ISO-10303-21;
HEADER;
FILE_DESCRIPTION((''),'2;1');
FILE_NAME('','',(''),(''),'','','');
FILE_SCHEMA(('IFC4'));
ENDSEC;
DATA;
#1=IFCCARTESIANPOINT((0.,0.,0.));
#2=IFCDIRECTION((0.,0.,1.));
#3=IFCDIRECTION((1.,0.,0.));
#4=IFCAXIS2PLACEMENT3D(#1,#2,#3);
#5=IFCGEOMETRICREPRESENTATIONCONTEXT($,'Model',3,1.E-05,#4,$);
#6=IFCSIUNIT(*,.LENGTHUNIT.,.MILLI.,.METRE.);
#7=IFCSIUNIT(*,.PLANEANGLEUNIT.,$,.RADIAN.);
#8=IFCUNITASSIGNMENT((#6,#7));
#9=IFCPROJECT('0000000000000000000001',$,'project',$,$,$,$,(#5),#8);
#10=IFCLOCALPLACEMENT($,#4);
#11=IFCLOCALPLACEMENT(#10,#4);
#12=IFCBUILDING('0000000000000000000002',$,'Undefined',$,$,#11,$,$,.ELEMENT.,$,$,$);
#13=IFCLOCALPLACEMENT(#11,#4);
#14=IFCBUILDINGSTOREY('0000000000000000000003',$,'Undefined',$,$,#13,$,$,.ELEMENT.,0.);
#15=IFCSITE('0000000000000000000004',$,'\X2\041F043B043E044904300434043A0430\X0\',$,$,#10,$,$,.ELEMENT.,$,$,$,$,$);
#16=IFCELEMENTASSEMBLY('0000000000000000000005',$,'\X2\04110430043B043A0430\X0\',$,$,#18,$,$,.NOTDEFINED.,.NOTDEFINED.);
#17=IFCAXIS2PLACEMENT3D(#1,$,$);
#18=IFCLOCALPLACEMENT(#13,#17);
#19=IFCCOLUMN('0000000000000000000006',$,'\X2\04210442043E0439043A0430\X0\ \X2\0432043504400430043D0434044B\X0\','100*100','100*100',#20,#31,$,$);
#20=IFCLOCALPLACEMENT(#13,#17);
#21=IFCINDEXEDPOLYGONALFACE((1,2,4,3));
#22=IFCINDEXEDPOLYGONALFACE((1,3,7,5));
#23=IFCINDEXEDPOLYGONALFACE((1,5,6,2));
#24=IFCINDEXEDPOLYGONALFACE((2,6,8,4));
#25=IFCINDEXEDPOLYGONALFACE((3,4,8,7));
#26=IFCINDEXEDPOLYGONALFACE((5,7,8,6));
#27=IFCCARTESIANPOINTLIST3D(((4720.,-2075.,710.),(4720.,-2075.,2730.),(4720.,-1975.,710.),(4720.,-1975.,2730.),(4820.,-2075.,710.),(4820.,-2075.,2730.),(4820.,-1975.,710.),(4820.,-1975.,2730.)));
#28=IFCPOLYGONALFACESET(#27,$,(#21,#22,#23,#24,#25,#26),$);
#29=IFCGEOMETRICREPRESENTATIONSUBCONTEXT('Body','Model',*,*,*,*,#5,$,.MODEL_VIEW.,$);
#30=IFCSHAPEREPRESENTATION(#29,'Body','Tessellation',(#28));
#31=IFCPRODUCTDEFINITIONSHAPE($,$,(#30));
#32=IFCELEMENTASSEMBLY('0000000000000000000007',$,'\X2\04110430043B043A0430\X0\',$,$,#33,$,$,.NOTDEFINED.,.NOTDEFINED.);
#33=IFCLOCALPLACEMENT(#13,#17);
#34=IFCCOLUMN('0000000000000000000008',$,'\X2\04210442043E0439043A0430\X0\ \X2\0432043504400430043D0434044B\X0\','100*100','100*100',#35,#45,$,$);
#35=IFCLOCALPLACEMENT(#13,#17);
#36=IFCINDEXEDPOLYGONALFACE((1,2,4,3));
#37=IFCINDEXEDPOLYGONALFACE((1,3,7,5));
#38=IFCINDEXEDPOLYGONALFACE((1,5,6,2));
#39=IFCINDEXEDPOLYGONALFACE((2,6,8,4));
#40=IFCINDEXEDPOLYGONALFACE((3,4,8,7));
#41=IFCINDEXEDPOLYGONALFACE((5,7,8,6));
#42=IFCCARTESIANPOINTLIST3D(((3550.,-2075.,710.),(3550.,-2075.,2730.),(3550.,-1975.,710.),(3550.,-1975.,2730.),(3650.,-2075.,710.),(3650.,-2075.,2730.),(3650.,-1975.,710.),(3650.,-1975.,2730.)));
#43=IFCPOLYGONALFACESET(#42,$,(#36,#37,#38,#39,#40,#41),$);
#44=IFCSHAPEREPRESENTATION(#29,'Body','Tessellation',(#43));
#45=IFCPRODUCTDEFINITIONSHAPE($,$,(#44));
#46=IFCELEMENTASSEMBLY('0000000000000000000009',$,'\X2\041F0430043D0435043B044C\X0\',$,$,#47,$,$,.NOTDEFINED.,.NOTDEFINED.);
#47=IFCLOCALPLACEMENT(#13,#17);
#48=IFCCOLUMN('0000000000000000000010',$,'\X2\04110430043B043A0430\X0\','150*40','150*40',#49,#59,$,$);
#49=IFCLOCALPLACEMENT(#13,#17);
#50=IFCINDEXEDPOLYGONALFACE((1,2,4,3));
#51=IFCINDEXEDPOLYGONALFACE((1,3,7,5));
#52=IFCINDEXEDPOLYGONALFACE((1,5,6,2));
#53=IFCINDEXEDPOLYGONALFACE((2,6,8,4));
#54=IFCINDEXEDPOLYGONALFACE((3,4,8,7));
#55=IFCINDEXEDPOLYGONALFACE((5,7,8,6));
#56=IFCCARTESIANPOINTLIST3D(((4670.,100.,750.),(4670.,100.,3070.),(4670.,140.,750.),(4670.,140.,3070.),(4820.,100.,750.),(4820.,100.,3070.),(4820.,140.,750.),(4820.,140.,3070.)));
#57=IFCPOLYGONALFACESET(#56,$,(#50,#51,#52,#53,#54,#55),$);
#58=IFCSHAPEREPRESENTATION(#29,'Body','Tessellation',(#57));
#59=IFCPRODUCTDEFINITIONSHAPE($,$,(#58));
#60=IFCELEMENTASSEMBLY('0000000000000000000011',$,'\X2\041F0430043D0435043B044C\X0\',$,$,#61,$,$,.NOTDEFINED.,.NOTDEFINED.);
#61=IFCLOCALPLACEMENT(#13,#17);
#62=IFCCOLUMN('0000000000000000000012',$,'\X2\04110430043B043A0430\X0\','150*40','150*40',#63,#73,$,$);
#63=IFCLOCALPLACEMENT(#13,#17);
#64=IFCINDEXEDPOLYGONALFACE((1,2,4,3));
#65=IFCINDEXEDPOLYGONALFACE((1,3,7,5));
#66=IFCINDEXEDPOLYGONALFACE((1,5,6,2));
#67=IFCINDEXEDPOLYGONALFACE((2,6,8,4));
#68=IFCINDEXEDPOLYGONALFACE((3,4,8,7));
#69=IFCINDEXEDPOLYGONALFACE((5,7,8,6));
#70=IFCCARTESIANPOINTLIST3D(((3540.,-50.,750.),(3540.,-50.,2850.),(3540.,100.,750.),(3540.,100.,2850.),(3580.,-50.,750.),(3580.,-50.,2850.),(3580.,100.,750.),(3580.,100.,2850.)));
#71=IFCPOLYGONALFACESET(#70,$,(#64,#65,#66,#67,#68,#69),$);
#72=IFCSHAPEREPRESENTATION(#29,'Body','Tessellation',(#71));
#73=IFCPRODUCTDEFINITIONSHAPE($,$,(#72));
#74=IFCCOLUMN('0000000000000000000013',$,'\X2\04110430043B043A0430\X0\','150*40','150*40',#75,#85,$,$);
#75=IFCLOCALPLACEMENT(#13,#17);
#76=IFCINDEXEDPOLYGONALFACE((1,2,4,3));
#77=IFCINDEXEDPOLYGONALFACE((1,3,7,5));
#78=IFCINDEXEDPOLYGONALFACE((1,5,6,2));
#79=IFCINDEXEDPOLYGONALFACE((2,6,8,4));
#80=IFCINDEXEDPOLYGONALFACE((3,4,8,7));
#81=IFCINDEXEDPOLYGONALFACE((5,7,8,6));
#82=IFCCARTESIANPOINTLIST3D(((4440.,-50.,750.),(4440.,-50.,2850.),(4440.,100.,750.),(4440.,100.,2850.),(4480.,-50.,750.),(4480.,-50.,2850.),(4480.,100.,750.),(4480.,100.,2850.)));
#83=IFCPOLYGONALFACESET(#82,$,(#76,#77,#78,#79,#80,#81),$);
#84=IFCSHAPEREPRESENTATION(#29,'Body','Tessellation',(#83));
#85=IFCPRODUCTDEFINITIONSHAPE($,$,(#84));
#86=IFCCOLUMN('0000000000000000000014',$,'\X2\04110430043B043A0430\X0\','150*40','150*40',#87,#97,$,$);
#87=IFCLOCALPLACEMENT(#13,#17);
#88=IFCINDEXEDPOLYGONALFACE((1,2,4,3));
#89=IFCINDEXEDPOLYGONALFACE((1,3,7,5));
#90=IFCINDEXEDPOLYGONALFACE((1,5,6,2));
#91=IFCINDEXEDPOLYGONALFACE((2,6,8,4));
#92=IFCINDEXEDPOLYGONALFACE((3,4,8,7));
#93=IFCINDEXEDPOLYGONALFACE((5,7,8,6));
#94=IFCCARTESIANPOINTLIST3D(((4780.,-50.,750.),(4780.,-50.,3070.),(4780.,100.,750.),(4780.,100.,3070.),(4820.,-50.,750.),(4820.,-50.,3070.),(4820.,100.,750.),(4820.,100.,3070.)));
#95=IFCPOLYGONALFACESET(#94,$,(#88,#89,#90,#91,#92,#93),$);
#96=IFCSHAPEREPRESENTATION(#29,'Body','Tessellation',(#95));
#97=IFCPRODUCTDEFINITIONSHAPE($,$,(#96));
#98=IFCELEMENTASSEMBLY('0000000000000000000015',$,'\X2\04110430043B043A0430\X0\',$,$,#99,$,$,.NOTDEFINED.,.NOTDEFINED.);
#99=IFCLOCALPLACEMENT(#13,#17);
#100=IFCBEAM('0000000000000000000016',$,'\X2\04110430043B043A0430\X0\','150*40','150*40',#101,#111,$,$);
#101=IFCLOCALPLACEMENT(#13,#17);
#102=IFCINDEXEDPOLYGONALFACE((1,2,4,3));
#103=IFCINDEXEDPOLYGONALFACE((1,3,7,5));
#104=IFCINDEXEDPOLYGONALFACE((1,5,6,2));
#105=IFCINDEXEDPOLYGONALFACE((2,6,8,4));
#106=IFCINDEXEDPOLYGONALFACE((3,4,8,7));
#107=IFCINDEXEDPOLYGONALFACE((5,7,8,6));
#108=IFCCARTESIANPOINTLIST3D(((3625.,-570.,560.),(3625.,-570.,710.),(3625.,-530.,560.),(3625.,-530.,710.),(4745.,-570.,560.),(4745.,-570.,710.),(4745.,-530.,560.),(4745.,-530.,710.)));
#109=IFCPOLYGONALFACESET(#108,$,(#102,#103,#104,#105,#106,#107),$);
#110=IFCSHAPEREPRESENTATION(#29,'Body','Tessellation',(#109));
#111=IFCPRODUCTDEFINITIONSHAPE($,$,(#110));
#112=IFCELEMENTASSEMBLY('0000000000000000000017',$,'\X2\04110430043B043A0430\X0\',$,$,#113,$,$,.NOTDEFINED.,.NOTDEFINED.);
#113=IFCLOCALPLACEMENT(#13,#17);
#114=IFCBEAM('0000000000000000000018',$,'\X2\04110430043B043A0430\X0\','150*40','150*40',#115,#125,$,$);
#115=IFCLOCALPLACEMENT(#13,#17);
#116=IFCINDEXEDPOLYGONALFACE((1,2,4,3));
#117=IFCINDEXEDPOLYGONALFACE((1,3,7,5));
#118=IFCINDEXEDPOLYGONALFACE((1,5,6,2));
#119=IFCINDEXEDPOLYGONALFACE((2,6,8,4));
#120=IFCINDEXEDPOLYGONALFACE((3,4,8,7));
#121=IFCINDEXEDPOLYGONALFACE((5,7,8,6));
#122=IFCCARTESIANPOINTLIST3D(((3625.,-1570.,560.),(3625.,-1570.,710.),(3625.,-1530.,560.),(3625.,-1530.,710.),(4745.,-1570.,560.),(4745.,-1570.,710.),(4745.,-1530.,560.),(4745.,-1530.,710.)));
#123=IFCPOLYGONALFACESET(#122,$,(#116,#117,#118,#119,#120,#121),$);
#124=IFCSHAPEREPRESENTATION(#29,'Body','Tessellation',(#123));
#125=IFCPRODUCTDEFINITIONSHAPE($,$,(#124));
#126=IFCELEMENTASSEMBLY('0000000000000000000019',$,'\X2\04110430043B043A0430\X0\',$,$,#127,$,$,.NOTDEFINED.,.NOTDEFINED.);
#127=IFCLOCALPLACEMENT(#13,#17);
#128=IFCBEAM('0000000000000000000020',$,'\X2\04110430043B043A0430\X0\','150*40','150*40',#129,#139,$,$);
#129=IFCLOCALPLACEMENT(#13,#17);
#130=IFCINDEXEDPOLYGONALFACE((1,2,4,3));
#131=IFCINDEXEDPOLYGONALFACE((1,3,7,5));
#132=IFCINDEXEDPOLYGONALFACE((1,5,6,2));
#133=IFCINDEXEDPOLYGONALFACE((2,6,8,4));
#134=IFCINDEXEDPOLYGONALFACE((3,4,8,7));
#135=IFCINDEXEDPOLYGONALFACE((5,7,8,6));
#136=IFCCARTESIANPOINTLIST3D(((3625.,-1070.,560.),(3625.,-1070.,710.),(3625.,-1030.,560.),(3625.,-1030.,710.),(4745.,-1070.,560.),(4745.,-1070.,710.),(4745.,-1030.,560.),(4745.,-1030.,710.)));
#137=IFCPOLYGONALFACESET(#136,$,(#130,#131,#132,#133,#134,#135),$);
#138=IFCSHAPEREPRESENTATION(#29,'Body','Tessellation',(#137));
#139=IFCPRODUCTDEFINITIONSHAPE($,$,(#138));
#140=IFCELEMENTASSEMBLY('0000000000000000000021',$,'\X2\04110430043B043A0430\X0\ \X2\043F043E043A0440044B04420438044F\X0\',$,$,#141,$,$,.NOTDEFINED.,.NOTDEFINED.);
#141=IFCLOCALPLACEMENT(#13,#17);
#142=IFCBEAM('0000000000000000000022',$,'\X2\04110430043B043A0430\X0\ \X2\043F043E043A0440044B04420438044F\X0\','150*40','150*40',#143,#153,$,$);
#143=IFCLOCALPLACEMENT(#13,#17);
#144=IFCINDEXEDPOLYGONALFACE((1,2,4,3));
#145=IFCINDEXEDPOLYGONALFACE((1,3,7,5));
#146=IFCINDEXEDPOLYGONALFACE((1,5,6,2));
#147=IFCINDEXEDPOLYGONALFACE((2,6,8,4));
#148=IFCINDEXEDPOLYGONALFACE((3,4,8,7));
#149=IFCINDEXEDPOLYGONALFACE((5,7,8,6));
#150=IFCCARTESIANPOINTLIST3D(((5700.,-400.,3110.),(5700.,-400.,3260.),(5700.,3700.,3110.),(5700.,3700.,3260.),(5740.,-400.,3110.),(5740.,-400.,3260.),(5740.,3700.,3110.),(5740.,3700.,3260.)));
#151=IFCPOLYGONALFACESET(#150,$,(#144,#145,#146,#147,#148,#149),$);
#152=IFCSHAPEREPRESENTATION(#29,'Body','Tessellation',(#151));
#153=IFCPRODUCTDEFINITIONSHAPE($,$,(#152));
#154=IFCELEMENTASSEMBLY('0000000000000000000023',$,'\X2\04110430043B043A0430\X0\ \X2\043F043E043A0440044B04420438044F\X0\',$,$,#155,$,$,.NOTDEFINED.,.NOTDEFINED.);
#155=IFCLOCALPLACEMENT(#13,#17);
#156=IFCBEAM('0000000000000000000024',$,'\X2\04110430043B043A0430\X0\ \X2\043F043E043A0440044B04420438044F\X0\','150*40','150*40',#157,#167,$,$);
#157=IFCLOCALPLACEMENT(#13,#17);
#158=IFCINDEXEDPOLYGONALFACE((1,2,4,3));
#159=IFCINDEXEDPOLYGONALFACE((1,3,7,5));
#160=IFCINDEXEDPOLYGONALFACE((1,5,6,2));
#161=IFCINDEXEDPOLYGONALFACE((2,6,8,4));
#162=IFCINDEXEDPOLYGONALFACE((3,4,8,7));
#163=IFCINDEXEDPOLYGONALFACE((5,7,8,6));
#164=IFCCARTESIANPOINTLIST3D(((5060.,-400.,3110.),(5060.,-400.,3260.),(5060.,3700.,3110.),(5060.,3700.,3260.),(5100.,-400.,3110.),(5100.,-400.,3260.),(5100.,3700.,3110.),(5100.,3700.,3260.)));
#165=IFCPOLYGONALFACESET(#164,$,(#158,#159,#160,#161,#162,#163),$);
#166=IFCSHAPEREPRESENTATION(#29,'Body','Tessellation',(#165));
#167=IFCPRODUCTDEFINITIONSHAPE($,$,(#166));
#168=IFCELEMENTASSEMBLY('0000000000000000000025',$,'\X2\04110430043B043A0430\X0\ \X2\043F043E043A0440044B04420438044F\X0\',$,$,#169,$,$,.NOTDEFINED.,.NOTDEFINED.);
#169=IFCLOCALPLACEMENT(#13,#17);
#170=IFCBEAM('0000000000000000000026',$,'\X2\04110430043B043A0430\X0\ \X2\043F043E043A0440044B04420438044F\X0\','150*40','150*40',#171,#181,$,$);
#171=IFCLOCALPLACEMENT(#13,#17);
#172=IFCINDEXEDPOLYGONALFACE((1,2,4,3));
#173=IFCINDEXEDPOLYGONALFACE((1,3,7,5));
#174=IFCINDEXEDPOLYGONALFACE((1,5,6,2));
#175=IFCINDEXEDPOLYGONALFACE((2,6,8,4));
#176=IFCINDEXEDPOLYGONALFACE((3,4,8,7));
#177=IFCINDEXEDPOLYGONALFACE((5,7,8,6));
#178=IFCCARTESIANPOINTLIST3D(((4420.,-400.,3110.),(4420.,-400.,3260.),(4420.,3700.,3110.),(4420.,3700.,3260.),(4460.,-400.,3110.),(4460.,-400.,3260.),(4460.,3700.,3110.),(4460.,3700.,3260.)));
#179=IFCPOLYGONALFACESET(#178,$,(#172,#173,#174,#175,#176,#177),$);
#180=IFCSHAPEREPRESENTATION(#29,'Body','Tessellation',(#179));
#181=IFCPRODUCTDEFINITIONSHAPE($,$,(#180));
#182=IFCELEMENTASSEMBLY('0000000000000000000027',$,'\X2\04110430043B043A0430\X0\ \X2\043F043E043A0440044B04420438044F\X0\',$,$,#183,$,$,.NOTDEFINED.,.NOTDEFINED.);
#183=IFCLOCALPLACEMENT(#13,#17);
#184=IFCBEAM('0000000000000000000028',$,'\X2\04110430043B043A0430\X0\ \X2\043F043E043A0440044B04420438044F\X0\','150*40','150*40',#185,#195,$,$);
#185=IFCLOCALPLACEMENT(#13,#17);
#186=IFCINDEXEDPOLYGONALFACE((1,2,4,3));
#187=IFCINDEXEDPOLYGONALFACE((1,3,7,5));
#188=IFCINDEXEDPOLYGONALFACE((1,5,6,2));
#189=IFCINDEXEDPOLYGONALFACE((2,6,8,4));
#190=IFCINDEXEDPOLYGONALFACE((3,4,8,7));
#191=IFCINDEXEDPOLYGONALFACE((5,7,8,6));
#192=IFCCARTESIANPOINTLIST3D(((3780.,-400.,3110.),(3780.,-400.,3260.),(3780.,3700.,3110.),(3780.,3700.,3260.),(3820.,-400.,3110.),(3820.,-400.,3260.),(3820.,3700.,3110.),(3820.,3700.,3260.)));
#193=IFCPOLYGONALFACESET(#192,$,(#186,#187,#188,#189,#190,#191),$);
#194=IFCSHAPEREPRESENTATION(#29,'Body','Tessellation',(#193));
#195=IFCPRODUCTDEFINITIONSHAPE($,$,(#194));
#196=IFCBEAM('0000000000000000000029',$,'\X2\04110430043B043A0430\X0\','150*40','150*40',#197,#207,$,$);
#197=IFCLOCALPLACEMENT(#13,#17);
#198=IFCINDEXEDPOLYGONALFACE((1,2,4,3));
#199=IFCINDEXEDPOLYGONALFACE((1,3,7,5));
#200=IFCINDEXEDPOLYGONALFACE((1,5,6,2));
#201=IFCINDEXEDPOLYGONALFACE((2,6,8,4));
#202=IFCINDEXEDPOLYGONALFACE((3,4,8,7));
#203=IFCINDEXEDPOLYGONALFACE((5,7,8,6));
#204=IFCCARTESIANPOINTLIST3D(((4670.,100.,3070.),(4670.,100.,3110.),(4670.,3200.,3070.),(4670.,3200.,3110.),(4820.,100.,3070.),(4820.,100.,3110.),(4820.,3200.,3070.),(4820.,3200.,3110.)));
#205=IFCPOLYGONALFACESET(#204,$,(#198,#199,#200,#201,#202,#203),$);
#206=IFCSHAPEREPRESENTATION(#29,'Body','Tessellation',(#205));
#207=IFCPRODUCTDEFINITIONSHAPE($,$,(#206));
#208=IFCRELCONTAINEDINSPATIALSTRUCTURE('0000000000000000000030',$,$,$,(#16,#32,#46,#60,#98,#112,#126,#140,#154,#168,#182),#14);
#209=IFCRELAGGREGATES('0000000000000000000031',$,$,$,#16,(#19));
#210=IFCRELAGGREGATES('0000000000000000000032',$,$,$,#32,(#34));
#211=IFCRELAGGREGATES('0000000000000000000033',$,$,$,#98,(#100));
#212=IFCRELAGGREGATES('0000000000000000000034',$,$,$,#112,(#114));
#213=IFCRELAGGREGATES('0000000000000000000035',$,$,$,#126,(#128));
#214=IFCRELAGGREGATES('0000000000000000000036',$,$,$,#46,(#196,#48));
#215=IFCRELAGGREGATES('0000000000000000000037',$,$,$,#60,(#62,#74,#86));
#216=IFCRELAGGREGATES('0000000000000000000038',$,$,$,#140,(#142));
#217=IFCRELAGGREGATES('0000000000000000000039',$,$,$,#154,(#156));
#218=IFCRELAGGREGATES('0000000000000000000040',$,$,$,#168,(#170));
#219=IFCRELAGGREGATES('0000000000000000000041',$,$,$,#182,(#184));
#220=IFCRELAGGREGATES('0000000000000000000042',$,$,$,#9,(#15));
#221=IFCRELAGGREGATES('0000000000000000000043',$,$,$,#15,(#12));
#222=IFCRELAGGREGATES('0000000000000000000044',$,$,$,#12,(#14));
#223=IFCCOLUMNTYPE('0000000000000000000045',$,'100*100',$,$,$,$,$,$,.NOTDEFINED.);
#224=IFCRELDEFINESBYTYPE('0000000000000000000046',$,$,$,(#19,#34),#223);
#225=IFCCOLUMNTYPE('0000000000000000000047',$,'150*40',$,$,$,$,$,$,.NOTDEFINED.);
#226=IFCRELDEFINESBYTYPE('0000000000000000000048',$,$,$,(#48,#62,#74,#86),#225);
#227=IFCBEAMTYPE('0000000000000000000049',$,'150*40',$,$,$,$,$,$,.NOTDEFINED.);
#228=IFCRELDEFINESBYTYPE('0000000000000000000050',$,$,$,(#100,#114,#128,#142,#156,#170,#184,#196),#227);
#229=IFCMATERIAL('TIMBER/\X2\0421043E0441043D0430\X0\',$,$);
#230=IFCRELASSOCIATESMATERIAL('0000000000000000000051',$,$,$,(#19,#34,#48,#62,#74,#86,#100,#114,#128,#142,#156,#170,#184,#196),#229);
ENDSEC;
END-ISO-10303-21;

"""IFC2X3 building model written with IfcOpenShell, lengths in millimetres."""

from ifc_helpers import new_model, si_unit, frame, origin_with_axes, origin_2d_with_axis, place, context, subcontext, project, spatial, rectangle, extrude, material, type_object, element, aggregate, save


model = new_model("IFC2X3")

# Units and contexts
model_context = context("Model", 3, precision=1e-05, world=origin_with_axes())
body_context = subcontext(model_context, "Body", "Model", "MODEL_VIEW")
ifc_project = project(units=[si_unit("LENGTHUNIT", "METRE", prefix="MILLI"), si_unit("PLANEANGLEUNIT", "RADIAN")], contexts=[model_context])

# Site, building, storey
site_placement = place(None, origin_with_axes())
site = spatial("IfcSite", under=ifc_project, at=site_placement, Name="Площадка", CompositionType="ELEMENT")
building_placement = place(site_placement, origin_with_axes())
building = spatial("IfcBuilding", under=site, at=building_placement, Name="Undefined", CompositionType="ELEMENT")
storey_placement = place(building_placement, origin_with_axes())
storey = spatial("IfcBuildingStorey", under=building, at=storey_placement, Name="Undefined", CompositionType="ELEMENT", Elevation=0.0)

# Element assemblies, columns
assembly_1_placement = place(storey_placement, origin_with_axes())
assembly_1 = element("IfcElementAssembly", 1, at=assembly_1_placement, inside=storey, Name="Балка", AssemblyPlace="NOTDEFINED", PredefinedType="NOTDEFINED")
ifc_material = material(Name="TIMBER/Сосна")
column_type_1 = type_object("IfcColumnType", Name="100*100", PredefinedType="NOTDEFINED")
column_1_placement = place(assembly_1_placement, frame((4770.0, -2025.0, 710.0), z_axis=(0.0, 0.0, 1.0), x_axis=(0.0, 1.0, 0.0)))
column_1 = element("IfcColumn", 2, at=column_1_placement, type_object=column_type_1, material=ifc_material, Name="Стойка веранды", Description="100*100", ObjectType="100*100", context=body_context, shape_type="SweptSolid", body=[
    extrude(rectangle(XDim=100.0, YDim=100.0, at=origin_2d_with_axis()), frame((0.0, 0.0, 2020.0), z_axis=(0.0, 0.0, -1.0), x_axis=(0.0, 1.0, 0.0)), (0.0, 0.0, 1.0), 2020.0),
])
aggregate(assembly_1, [column_1])
assembly_2_placement = place(storey_placement, origin_with_axes())
assembly_2 = element("IfcElementAssembly", 3, at=assembly_2_placement, inside=storey, Name="Балка", AssemblyPlace="NOTDEFINED", PredefinedType="NOTDEFINED")
column_2_placement = place(assembly_2_placement, frame((3600.0, -2025.0, 710.0), z_axis=(0.0, 0.0, 1.0), x_axis=(0.0, 1.0, 0.0)))
column_2 = element("IfcColumn", 4, at=column_2_placement, type_object=column_type_1, material=ifc_material, Name="Стойка веранды", Description="100*100", ObjectType="100*100", context=body_context, shape_type="SweptSolid", body=[
    extrude(rectangle(XDim=100.0, YDim=100.0, at=origin_2d_with_axis()), frame((0.0, 0.0, 2020.0), z_axis=(0.0, 0.0, -1.0), x_axis=(0.0, 1.0, 0.0)), (0.0, 0.0, 1.0), 2020.0),
])
aggregate(assembly_2, [column_2])
assembly_3_placement = place(storey_placement, origin_with_axes())
assembly_3 = element("IfcElementAssembly", 5, at=assembly_3_placement, inside=storey, Name="Панель", AssemblyPlace="NOTDEFINED", PredefinedType="NOTDEFINED")
column_type_2 = type_object("IfcColumnType", Name="150*40", PredefinedType="NOTDEFINED")
column_3_placement = place(assembly_3_placement, frame((4745.0, 120.0, 750.0), z_axis=(0.0, 0.0, 1.0), x_axis=(-1.0, 0.0, 0.0)))
column_3 = element("IfcColumn", 6, at=column_3_placement, type_object=column_type_2, material=ifc_material, Name="Балка", Description="150*40", ObjectType="150*40", context=body_context, shape_type="SweptSolid", body=[
    extrude(rectangle(XDim=40.0, YDim=150.0, at=origin_2d_with_axis()), frame((0.0, 0.0, 2320.0), z_axis=(0.0, 0.0, -1.0), x_axis=(0.0, 1.0, 0.0)), (0.0, 0.0, 1.0), 2320.0),
])

# Element assembly, columns
assembly_4_placement = place(storey_placement, origin_with_axes())
assembly_4 = element("IfcElementAssembly", 7, at=assembly_4_placement, inside=storey, Name="Панель", AssemblyPlace="NOTDEFINED", PredefinedType="NOTDEFINED")
column_4_placement = place(assembly_4_placement, frame((3560.0, 25.0, 750.0), z_axis=(0.0, 0.0, 1.0), x_axis=(0.0, 1.0, 0.0)))
column_4 = element("IfcColumn", 8, at=column_4_placement, type_object=column_type_2, material=ifc_material, Name="Балка", Description="150*40", ObjectType="150*40", context=body_context, shape_type="SweptSolid", body=[
    extrude(rectangle(XDim=40.0, YDim=150.0, at=origin_2d_with_axis()), frame((0.0, 0.0, 2100.0), z_axis=(0.0, 0.0, -1.0), x_axis=(0.0, 1.0, 0.0)), (0.0, 0.0, 1.0), 2100.0),
])
column_5_placement = place(assembly_4_placement, frame((4460.0, 25.0, 750.0), z_axis=(0.0, 0.0, 1.0), x_axis=(0.0, 1.0, 0.0)))
column_5 = element("IfcColumn", 9, at=column_5_placement, type_object=column_type_2, material=ifc_material, Name="Балка", Description="150*40", ObjectType="150*40", context=body_context, shape_type="SweptSolid", body=[
    extrude(rectangle(XDim=40.0, YDim=150.0, at=origin_2d_with_axis()), frame((0.0, 0.0, 2100.0), z_axis=(0.0, 0.0, -1.0), x_axis=(0.0, 1.0, 0.0)), (0.0, 0.0, 1.0), 2100.0),
])
column_6_placement = place(assembly_4_placement, frame((4800.0, 25.0, 750.0), z_axis=(0.0, 0.0, 1.0), x_axis=(0.0, 1.0, 0.0)))
column_6 = element("IfcColumn", 10, at=column_6_placement, type_object=column_type_2, material=ifc_material, Name="Балка", Description="150*40", ObjectType="150*40", context=body_context, shape_type="SweptSolid", body=[
    extrude(rectangle(XDim=40.0, YDim=150.0, at=origin_2d_with_axis()), frame((0.0, 0.0, 2320.0), z_axis=(0.0, 0.0, -1.0), x_axis=(0.0, 1.0, 0.0)), (0.0, 0.0, 1.0), 2320.0),
])

# Element assemblies, beams
assembly_5_placement = place(storey_placement, origin_with_axes())
assembly_5 = element("IfcElementAssembly", 11, at=assembly_5_placement, inside=storey, Name="Балка", AssemblyPlace="NOTDEFINED", PredefinedType="NOTDEFINED")
beam_type_1 = type_object("IfcBeamType", Name="150*40", PredefinedType="NOTDEFINED")
beam_1_placement = place(assembly_5_placement, frame((4745.0, -550.0, 635.0), z_axis=(0.0, 0.0, -1.0), x_axis=(-1.0, 0.0, 0.0)))
beam_1 = element("IfcBeam", 12, at=beam_1_placement, type_object=beam_type_1, material=ifc_material, Name="Балка", Description="150*40", ObjectType="150*40", context=body_context, shape_type="SweptSolid", body=[
    extrude(rectangle(XDim=40.0, YDim=150.0, at=origin_2d_with_axis()), frame((1120.0, 0.0, 0.0), z_axis=(-1.0, 0.0, 0.0), x_axis=(0.0, -1.0, 0.0)), (0.0, 0.0, 1.0), 1120.0),
])
aggregate(assembly_5, [beam_1])
assembly_6_placement = place(storey_placement, origin_with_axes())
assembly_6 = element("IfcElementAssembly", 13, at=assembly_6_placement, inside=storey, Name="Балка", AssemblyPlace="NOTDEFINED", PredefinedType="NOTDEFINED")
beam_2_placement = place(assembly_6_placement, frame((4745.0, -1550.0, 635.0), z_axis=(0.0, 0.0, -1.0), x_axis=(-1.0, 0.0, 0.0)))
beam_2 = element("IfcBeam", 14, at=beam_2_placement, type_object=beam_type_1, material=ifc_material, Name="Балка", Description="150*40", ObjectType="150*40", context=body_context, shape_type="SweptSolid", body=[
    extrude(rectangle(XDim=40.0, YDim=150.0, at=origin_2d_with_axis()), frame((1120.0, 0.0, 0.0), z_axis=(-1.0, 0.0, 0.0), x_axis=(0.0, -1.0, 0.0)), (0.0, 0.0, 1.0), 1120.0),
])
aggregate(assembly_6, [beam_2])
assembly_7_placement = place(storey_placement, origin_with_axes())
assembly_7 = element("IfcElementAssembly", 15, at=assembly_7_placement, inside=storey, Name="Балка", AssemblyPlace="NOTDEFINED", PredefinedType="NOTDEFINED")
beam_3_placement = place(assembly_7_placement, frame((4745.0, -1050.0, 635.0), z_axis=(0.0, 0.0, -1.0), x_axis=(-1.0, 0.0, 0.0)))
beam_3 = element("IfcBeam", 16, at=beam_3_placement, type_object=beam_type_1, material=ifc_material, Name="Балка", Description="150*40", ObjectType="150*40", context=body_context, shape_type="SweptSolid", body=[
    extrude(rectangle(XDim=40.0, YDim=150.0, at=origin_2d_with_axis()), frame((1120.0, 0.0, 0.0), z_axis=(-1.0, 0.0, 0.0), x_axis=(0.0, -1.0, 0.0)), (0.0, 0.0, 1.0), 1120.0),
])
aggregate(assembly_7, [beam_3])
assembly_8_placement = place(storey_placement, origin_with_axes())
assembly_8 = element("IfcElementAssembly", 17, at=assembly_8_placement, inside=storey, Name="Балка покрытия", AssemblyPlace="NOTDEFINED", PredefinedType="NOTDEFINED")
beam_4_placement = place(assembly_8_placement, frame((5720.0, -400.0, 3185.0), z_axis=(0.0, 0.0, -1.0), x_axis=(0.0, 1.0, 0.0)))
beam_4 = element("IfcBeam", 18, at=beam_4_placement, type_object=beam_type_1, material=ifc_material, Name="Балка покрытия", Description="150*40", ObjectType="150*40", context=body_context, shape_type="SweptSolid", body=[
    extrude(rectangle(XDim=40.0, YDim=150.0, at=origin_2d_with_axis()), frame((4100.0, 0.0, 0.0), z_axis=(-1.0, 0.0, 0.0), x_axis=(0.0, -1.0, 0.0)), (0.0, 0.0, 1.0), 4100.0),
])
assembly_9_placement = place(storey_placement, origin_with_axes())
assembly_9 = element("IfcElementAssembly", 19, at=assembly_9_placement, inside=storey, Name="Балка покрытия", AssemblyPlace="NOTDEFINED", PredefinedType="NOTDEFINED")
beam_5_placement = place(assembly_9_placement, frame((5080.0, -400.0, 3185.0), z_axis=(0.0, 0.0, -1.0), x_axis=(0.0, 1.0, 0.0)))
beam_5 = element("IfcBeam", 20, at=beam_5_placement, type_object=beam_type_1, material=ifc_material, Name="Балка покрытия", Description="150*40", ObjectType="150*40", context=body_context, shape_type="SweptSolid", body=[
    extrude(rectangle(XDim=40.0, YDim=150.0, at=origin_2d_with_axis()), frame((4100.0, 0.0, 0.0), z_axis=(-1.0, 0.0, 0.0), x_axis=(0.0, -1.0, 0.0)), (0.0, 0.0, 1.0), 4100.0),
])
assembly_10_placement = place(storey_placement, origin_with_axes())
assembly_10 = element("IfcElementAssembly", 21, at=assembly_10_placement, inside=storey, Name="Балка покрытия", AssemblyPlace="NOTDEFINED", PredefinedType="NOTDEFINED")
beam_6_placement = place(assembly_10_placement, frame((4440.0, -400.0, 3185.0), z_axis=(0.0, 0.0, -1.0), x_axis=(0.0, 1.0, 0.0)))
beam_6 = element("IfcBeam", 22, at=beam_6_placement, type_object=beam_type_1, material=ifc_material, Name="Балка покрытия", Description="150*40", ObjectType="150*40", context=body_context, shape_type="SweptSolid", body=[
    extrude(rectangle(XDim=40.0, YDim=150.0, at=origin_2d_with_axis()), frame((4100.0, 0.0, 0.0), z_axis=(-1.0, 0.0, 0.0), x_axis=(0.0, -1.0, 0.0)), (0.0, 0.0, 1.0), 4100.0),
])
assembly_11_placement = place(storey_placement, origin_with_axes())
assembly_11 = element("IfcElementAssembly", 23, at=assembly_11_placement, inside=storey, Name="Балка покрытия", AssemblyPlace="NOTDEFINED", PredefinedType="NOTDEFINED")
beam_7_placement = place(assembly_11_placement, frame((3800.0, -400.0, 3185.0), z_axis=(0.0, 0.0, -1.0), x_axis=(0.0, 1.0, 0.0)))
beam_7 = element("IfcBeam", 24, at=beam_7_placement, type_object=beam_type_1, material=ifc_material, Name="Балка покрытия", Description="150*40", ObjectType="150*40", context=body_context, shape_type="SweptSolid", body=[
    extrude(rectangle(XDim=40.0, YDim=150.0, at=origin_2d_with_axis()), frame((4100.0, 0.0, 0.0), z_axis=(-1.0, 0.0, 0.0), x_axis=(0.0, -1.0, 0.0)), (0.0, 0.0, 1.0), 4100.0),
])

# Beam
beam_8_placement = place(assembly_3_placement, frame((4745.0, 100.0, 3090.0), z_axis=(-1.0, 0.0, 0.0), x_axis=(0.0, 1.0, 0.0)))
beam_8 = element("IfcBeam", 25, at=beam_8_placement, type_object=beam_type_1, material=ifc_material, Name="Балка", Description="150*40", ObjectType="150*40", context=body_context, shape_type="SweptSolid", body=[
    extrude(rectangle(XDim=40.0, YDim=150.0, at=origin_2d_with_axis()), frame((3100.0, 0.0, 0.0), z_axis=(-1.0, 0.0, 0.0), x_axis=(0.0, -1.0, 0.0)), (0.0, 0.0, 1.0), 3100.0),
])
aggregate(assembly_3, [beam_8, column_3])
aggregate(assembly_4, [column_4, column_5, column_6])

aggregate(assembly_8, [beam_4])
aggregate(assembly_9, [beam_5])
aggregate(assembly_10, [beam_6])
aggregate(assembly_11, [beam_7])

save(model, "model.ifc")
